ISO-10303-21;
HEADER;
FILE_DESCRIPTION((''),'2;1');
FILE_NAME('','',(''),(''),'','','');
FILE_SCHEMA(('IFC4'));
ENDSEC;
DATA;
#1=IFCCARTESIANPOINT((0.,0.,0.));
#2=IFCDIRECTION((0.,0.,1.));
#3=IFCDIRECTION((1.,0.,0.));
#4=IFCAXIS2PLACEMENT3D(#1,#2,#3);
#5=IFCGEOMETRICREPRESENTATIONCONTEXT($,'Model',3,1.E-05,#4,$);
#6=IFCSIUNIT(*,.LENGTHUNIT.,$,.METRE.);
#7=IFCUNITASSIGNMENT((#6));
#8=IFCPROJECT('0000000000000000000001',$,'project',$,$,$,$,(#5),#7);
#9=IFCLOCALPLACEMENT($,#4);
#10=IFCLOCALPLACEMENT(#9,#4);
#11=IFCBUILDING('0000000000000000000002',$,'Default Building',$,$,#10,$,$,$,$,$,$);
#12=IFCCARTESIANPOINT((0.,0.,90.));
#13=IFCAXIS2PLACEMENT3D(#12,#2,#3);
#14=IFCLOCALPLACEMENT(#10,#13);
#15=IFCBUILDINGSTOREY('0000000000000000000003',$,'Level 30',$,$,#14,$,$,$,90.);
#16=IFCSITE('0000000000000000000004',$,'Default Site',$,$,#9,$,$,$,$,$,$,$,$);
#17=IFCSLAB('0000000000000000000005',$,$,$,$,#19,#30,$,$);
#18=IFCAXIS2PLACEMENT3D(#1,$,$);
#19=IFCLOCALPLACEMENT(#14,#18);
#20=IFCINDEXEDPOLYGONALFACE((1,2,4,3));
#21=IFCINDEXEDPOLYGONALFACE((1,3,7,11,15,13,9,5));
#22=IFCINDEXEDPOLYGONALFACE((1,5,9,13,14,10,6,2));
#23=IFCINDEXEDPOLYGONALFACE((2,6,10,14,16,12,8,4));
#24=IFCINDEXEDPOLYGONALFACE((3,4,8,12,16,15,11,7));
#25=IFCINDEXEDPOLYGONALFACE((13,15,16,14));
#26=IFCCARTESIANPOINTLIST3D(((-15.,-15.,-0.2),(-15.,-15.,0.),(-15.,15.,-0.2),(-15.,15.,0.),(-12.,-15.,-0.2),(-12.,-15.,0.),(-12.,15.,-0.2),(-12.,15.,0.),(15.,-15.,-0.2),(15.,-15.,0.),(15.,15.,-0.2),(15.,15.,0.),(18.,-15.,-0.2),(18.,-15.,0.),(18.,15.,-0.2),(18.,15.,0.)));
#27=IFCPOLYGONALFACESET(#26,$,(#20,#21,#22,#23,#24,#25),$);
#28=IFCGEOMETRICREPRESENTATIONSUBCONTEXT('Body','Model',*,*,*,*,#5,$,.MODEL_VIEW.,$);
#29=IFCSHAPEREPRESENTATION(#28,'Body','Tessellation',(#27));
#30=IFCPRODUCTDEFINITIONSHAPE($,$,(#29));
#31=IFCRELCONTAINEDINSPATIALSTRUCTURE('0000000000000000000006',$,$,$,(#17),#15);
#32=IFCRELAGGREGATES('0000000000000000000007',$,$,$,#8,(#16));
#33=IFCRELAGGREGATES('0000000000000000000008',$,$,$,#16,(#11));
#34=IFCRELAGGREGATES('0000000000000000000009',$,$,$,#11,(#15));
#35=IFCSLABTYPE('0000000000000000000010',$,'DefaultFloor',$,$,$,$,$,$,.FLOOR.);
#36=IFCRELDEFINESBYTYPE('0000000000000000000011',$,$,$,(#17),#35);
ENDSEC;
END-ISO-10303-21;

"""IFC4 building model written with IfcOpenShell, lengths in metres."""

from ifc_helpers import new_model, si_unit, frame, origin_with_axes, place, context, subcontext, project, spatial, polyline, outline, extrude, type_object, element, save


model = new_model("IFC4")

# Units and contexts
model_context = context("Model", 3, precision=1e-05, world=origin_with_axes())
body_context = subcontext(model_context, "Body", "Model", "MODEL_VIEW")
ifc_project = project(units=[si_unit("LENGTHUNIT", "METRE")], contexts=[model_context])

# Site, building, storey
site_placement = place(None, origin_with_axes())
site = spatial("IfcSite", under=ifc_project, at=site_placement, Name="Default Site")
building_placement = place(site_placement, origin_with_axes())
building = spatial("IfcBuilding", under=site, at=building_placement, Name="Default Building")
storey_placement = place(building_placement, frame((0.0, 0.0, 90.0), z_axis=(0.0, 0.0, 1.0), x_axis=(1.0, 0.0, 0.0)))
storey = spatial("IfcBuildingStorey", under=building, at=storey_placement, Name="Level 30", Elevation=90.0)

# Slab
slab_type = type_object("IfcSlabType", Name="DefaultFloor", PredefinedType="FLOOR")
slab_placement = place(storey_placement, frame((0.0, 0.0, -90.0), z_axis=(0.0, 0.0, 1.0), x_axis=(1.0, 0.0, 0.0)))
element("IfcSlab", 1, at=slab_placement, inside=storey, type_object=slab_type, context=body_context, shape_type="SweptSolid", body=[
    extrude(outline(polyline([(-15.0, 15.0), (-12.0, 15.0), (15.0, 15.0), (18.0, 15.0), (18.0, -15.0), (15.0, -15.0), (-12.0, -15.0), (-15.0, -15.0), (-15.0, 15.0)])), frame((0.0, 0.0, 90.0), z_axis=(0.0, 0.0, 1.0), x_axis=(1.0, 0.0, 0.0)), (0.0, 0.0, -1.0), 0.2),
])

save(model, "model.ifc")
